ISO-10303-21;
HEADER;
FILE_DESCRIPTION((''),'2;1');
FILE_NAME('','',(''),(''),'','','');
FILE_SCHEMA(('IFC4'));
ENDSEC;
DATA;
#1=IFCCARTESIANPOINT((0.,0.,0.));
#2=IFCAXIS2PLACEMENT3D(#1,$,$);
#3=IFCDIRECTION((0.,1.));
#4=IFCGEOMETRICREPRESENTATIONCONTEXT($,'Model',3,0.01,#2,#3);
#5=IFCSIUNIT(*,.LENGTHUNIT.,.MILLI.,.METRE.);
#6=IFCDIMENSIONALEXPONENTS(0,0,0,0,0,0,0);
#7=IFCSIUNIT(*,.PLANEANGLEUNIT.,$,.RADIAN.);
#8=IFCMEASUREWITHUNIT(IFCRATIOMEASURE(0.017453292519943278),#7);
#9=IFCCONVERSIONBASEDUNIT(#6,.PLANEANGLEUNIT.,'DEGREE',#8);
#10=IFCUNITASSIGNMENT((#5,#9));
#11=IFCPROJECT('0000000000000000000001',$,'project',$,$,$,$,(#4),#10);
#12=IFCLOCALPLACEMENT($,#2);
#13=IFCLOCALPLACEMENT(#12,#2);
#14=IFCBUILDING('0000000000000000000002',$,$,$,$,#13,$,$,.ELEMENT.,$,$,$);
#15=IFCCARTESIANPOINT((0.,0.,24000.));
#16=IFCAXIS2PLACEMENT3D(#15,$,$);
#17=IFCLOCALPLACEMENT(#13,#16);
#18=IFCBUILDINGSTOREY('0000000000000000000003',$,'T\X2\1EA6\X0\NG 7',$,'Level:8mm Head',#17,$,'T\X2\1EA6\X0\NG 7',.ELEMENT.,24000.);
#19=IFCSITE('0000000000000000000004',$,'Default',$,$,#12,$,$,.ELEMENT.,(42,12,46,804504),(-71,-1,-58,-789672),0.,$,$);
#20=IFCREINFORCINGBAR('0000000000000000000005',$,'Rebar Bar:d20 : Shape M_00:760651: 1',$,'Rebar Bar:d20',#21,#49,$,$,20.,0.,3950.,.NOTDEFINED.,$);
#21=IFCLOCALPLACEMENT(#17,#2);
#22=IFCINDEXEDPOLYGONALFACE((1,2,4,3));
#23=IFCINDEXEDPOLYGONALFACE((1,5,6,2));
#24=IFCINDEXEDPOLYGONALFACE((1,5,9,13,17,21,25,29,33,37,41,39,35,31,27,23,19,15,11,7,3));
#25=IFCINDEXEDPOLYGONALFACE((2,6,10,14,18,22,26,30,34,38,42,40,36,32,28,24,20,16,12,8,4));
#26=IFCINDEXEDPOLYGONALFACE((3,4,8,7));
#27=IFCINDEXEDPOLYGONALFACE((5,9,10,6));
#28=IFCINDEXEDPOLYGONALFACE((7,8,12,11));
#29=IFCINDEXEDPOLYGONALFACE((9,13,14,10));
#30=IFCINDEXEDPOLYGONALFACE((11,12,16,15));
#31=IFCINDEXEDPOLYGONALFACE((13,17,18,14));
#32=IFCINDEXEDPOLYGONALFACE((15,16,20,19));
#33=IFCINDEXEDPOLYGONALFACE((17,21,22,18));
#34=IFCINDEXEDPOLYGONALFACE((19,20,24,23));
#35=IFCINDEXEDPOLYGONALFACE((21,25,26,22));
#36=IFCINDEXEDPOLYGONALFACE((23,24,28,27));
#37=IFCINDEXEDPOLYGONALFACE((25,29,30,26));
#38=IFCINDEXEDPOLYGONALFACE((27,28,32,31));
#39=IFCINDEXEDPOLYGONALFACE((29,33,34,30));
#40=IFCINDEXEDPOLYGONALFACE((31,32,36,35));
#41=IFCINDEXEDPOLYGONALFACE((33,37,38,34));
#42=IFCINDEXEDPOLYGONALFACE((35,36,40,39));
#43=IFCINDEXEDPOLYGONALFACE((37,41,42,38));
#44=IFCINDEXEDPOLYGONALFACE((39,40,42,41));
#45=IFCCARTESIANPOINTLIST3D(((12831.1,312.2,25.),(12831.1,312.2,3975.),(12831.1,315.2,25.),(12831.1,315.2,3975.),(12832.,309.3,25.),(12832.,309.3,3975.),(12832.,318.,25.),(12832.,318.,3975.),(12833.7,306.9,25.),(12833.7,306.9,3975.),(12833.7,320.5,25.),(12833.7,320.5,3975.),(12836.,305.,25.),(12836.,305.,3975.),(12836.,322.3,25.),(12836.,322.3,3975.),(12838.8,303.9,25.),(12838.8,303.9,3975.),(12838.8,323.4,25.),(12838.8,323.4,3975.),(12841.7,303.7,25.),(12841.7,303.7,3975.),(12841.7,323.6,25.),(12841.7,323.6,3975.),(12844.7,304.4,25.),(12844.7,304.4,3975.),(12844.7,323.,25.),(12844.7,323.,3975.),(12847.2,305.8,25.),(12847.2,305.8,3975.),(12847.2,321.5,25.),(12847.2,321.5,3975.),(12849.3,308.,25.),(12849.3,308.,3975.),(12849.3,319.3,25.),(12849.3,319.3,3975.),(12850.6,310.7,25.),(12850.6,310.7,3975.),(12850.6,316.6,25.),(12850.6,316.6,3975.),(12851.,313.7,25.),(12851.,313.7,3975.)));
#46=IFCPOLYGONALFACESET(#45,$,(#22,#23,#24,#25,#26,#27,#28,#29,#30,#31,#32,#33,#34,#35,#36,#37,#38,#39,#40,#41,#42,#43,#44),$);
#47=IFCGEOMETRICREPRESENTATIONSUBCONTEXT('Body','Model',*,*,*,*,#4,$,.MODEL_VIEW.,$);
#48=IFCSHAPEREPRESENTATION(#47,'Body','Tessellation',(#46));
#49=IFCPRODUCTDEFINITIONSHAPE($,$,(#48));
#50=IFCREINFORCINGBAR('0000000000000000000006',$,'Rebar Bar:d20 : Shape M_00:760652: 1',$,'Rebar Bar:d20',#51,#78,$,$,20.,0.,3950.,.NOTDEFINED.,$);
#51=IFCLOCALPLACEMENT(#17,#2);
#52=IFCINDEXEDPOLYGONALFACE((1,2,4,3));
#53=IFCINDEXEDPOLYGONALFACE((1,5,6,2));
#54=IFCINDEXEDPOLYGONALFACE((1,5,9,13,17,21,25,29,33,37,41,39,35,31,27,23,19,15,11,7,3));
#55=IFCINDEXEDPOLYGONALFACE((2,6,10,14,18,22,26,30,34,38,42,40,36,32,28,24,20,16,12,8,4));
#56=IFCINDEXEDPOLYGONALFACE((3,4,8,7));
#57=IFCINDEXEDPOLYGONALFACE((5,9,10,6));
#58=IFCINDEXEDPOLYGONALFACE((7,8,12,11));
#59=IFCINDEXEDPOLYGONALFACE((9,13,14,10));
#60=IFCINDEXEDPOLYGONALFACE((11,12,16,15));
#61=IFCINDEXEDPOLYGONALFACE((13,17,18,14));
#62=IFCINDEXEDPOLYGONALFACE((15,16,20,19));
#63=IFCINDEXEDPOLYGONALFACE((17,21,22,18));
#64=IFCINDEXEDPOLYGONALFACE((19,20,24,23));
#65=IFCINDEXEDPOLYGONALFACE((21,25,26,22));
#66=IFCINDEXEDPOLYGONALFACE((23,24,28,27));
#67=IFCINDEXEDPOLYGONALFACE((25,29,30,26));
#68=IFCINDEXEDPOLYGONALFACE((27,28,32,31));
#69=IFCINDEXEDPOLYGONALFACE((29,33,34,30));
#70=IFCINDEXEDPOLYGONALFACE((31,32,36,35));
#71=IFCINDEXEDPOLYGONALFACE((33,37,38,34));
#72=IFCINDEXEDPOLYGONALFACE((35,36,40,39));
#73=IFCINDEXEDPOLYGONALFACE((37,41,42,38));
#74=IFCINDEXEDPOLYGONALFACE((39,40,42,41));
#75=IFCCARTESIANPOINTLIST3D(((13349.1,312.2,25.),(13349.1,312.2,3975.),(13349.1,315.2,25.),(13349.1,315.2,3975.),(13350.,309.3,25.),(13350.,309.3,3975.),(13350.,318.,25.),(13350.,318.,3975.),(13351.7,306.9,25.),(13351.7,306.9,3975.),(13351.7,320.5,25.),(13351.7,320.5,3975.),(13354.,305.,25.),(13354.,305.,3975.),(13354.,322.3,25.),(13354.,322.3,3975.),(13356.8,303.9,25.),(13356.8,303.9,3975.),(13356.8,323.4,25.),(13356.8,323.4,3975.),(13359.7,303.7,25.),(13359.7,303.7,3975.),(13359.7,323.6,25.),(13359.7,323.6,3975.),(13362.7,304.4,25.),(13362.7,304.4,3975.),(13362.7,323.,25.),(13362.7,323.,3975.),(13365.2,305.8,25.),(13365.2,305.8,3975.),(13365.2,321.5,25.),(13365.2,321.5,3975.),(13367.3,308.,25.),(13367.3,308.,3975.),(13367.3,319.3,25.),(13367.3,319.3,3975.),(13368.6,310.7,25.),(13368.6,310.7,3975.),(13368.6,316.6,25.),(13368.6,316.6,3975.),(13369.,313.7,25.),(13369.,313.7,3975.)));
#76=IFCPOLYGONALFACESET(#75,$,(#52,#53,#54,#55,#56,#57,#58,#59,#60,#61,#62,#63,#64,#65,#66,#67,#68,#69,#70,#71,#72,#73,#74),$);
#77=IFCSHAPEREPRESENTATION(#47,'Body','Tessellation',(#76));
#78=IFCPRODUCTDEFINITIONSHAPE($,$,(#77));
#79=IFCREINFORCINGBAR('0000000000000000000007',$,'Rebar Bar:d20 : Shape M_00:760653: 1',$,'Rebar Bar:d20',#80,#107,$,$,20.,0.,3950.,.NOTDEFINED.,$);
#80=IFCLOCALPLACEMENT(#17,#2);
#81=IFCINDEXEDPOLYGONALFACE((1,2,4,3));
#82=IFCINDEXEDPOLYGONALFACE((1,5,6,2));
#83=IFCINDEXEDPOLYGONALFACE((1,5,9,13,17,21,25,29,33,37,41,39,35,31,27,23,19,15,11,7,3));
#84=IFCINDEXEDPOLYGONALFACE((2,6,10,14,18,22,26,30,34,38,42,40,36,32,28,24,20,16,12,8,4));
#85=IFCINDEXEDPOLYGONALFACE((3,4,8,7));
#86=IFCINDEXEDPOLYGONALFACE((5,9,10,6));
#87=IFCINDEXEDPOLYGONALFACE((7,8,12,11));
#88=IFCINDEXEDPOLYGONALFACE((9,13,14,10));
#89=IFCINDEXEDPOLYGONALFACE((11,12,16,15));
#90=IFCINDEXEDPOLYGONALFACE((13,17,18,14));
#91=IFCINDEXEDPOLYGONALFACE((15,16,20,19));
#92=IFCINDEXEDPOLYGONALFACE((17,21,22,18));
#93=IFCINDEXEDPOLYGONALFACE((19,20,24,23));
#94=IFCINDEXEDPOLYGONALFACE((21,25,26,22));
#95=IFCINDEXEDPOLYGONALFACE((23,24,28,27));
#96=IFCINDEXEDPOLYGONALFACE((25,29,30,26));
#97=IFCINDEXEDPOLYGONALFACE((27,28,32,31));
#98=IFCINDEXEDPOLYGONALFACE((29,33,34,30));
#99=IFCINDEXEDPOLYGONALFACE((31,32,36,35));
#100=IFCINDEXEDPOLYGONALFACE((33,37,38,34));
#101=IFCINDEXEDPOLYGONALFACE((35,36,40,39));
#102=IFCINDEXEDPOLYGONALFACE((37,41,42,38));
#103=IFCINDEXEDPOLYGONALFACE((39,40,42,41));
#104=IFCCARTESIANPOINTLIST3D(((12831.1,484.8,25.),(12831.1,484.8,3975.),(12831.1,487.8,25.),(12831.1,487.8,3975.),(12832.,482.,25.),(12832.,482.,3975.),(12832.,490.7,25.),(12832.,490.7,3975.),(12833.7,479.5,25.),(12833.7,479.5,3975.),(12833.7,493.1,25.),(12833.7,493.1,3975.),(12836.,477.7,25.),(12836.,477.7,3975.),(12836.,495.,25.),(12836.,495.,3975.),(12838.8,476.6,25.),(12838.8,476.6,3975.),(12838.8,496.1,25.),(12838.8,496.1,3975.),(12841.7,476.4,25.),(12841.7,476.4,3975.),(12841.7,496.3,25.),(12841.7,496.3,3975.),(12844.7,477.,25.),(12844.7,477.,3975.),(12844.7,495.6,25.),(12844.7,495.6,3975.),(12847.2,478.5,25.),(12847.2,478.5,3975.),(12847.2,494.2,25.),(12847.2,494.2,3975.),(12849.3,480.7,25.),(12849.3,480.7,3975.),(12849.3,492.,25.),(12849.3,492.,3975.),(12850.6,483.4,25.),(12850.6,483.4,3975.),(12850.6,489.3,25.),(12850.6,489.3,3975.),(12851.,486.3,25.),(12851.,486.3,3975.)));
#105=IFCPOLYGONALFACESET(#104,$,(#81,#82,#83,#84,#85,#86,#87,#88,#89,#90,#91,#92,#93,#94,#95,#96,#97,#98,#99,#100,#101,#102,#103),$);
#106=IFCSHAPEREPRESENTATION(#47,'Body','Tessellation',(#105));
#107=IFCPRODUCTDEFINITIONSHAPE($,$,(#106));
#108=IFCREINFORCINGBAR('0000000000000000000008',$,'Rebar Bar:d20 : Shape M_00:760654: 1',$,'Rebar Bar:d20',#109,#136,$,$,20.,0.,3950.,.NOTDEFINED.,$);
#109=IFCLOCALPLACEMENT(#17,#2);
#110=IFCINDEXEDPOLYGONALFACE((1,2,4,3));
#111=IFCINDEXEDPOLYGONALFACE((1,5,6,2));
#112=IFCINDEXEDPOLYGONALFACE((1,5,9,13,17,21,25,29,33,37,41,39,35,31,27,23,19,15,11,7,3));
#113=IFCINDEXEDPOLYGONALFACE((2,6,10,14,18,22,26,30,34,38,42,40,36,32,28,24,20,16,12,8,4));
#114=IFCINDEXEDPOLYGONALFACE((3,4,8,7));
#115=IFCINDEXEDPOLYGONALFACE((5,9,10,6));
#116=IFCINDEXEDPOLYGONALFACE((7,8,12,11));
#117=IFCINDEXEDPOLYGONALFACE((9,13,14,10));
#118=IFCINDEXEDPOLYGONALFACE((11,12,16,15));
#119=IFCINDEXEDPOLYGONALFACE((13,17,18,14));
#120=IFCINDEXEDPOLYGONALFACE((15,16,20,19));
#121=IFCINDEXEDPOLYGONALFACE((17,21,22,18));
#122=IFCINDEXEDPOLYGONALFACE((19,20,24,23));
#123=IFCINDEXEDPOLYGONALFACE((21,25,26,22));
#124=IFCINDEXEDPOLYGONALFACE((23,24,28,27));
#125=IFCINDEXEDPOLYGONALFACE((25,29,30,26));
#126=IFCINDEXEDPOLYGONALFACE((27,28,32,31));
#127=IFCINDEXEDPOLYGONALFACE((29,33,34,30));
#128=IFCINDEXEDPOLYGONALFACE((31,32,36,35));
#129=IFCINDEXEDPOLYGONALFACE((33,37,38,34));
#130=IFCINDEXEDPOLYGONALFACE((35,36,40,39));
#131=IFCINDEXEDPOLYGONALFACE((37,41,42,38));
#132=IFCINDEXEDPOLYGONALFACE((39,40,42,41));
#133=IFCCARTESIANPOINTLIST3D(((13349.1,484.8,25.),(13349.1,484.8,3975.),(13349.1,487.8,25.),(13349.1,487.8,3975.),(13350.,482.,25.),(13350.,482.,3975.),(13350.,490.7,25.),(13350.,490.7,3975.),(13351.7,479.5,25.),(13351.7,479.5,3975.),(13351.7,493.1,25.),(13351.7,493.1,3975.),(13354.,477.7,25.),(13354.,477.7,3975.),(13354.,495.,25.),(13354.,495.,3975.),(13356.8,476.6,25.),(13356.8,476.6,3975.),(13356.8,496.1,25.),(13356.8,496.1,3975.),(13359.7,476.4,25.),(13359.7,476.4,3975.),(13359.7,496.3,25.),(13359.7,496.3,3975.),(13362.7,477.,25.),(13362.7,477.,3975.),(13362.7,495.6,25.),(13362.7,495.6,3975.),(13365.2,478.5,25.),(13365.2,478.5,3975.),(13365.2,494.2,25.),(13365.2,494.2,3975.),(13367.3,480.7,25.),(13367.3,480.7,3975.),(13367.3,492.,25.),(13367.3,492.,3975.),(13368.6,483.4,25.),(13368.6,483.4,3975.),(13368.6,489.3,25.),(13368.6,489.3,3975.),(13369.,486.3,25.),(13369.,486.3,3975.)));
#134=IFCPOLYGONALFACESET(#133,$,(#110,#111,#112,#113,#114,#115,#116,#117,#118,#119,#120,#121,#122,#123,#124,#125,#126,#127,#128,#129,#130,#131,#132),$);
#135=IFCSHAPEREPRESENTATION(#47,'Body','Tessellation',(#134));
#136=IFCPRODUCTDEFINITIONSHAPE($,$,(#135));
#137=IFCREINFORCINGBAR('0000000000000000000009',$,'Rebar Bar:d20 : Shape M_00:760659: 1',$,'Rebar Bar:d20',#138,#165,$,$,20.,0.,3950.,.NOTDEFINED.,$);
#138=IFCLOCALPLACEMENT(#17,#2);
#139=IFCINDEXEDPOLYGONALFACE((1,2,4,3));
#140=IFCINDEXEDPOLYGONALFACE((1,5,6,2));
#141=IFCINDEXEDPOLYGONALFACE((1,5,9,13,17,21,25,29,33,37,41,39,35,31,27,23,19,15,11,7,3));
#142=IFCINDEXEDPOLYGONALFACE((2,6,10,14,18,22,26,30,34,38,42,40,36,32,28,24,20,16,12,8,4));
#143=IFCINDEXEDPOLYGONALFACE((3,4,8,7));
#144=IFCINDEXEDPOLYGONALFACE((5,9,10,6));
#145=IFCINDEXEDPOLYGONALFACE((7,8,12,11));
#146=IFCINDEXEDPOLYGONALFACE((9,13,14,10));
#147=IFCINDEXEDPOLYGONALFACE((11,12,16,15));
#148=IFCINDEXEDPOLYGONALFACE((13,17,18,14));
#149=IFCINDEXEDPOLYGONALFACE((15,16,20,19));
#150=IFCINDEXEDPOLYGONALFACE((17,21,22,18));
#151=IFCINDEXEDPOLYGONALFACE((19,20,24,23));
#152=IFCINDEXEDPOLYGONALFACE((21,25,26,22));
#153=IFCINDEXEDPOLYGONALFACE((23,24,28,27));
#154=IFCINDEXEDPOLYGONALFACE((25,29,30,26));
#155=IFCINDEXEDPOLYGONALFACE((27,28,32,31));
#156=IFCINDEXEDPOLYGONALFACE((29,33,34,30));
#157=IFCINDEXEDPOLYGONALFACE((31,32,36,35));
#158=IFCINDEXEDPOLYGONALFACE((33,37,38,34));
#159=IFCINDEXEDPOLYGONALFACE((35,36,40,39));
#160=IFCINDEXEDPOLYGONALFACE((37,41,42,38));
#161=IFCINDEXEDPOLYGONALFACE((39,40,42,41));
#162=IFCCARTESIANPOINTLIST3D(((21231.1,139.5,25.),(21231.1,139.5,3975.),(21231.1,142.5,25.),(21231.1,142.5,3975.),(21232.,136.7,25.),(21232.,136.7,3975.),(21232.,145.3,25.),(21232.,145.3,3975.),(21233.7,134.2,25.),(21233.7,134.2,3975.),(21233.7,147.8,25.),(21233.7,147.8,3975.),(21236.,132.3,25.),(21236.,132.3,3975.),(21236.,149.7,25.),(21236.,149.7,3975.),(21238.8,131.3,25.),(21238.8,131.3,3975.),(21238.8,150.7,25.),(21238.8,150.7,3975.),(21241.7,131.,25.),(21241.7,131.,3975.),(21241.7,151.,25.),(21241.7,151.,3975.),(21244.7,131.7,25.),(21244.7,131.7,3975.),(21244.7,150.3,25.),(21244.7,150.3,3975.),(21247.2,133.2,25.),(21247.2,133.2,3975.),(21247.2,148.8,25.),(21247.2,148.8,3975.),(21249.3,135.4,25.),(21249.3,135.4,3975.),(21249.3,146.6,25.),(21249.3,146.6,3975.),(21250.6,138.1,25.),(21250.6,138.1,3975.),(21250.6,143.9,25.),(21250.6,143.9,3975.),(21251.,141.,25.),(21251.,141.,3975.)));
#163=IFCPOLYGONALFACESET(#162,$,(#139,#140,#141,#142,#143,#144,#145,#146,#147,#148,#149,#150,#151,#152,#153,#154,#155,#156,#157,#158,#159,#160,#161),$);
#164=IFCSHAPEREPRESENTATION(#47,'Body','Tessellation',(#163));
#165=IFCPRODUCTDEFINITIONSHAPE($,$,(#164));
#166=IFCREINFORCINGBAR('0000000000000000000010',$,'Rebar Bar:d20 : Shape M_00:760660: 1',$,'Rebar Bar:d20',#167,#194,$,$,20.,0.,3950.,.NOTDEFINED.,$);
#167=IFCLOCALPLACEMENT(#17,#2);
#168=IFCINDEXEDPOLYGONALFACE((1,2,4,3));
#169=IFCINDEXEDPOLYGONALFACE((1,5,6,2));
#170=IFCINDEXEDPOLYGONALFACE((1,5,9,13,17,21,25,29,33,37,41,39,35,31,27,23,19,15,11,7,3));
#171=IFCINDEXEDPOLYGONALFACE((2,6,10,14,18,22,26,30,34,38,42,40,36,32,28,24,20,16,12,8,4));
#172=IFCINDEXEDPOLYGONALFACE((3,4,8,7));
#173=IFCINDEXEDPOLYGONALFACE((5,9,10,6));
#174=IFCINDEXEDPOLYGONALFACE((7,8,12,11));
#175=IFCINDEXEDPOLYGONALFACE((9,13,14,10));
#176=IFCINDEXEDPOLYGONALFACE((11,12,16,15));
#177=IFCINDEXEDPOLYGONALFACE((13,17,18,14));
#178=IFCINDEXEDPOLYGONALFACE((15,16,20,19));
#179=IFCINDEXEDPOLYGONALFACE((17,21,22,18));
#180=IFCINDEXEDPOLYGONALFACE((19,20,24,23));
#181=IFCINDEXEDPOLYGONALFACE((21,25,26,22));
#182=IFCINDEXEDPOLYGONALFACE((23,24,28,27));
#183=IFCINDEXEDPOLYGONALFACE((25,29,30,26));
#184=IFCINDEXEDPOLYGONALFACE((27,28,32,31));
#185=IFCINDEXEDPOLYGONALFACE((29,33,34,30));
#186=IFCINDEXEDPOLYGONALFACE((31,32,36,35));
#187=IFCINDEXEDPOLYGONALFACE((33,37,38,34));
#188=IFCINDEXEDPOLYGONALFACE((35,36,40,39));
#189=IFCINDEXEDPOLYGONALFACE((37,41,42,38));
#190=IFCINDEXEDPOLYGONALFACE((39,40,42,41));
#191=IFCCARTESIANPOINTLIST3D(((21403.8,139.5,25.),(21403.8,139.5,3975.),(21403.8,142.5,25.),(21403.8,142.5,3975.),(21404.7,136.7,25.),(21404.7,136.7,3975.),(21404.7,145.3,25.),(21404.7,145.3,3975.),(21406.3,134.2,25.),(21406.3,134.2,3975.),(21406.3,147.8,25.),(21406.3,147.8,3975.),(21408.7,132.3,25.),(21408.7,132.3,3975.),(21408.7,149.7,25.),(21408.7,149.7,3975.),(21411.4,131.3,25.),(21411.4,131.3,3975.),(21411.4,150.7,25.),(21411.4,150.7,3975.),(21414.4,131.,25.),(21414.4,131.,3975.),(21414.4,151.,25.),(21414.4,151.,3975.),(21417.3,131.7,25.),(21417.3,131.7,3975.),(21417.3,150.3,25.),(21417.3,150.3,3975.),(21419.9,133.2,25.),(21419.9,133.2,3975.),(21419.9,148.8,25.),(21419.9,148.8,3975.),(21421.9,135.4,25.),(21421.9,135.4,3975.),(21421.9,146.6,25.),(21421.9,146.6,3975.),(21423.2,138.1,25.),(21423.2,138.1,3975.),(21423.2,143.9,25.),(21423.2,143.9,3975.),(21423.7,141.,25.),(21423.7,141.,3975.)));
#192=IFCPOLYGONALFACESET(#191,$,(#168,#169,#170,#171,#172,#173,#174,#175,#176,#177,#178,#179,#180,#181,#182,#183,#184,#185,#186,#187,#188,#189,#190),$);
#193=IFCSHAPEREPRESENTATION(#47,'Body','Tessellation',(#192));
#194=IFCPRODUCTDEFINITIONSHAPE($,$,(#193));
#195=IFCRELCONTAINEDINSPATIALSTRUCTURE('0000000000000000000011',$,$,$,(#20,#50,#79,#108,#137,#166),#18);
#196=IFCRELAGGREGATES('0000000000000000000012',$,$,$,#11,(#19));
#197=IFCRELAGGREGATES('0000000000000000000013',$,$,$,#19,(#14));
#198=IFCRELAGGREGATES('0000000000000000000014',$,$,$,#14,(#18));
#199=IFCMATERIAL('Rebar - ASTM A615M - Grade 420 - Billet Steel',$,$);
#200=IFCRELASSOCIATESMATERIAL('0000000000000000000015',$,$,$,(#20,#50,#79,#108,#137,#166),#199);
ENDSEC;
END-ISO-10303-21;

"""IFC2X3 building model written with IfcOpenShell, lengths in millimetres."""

from ifc_helpers import new_model, entity, si_unit, converted_unit, direction, frame, origin, place, context, subcontext, project, spatial, material, element, save


model = new_model("IFC2X3")

# Units and contexts
model_context = context("Model", 3, precision=0.01, world=origin(), true_north=direction((0.0, 1.0)))
body_context = subcontext(model_context, "Body", "Model", "MODEL_VIEW")
ifc_project = project(units=[si_unit("LENGTHUNIT", "METRE", prefix="MILLI"), converted_unit("PLANEANGLEUNIT", "DEGREE", entity("IfcRatioMeasure", 0.017453292519943278), si_unit("PLANEANGLEUNIT", "RADIAN"), dimensions=[0, 0, 0, 0, 0, 0, 0])], contexts=[model_context])

# Site, building, storey
site_placement = place(None, origin())
site = spatial("IfcSite", under=ifc_project, at=site_placement, Name="Default", CompositionType="ELEMENT", RefLatitude=(42, 12, 46, 804504), RefLongitude=(-71, -1, -58, -789672), RefElevation=0.0)
building_placement = place(site_placement, origin())
building = spatial("IfcBuilding", under=site, at=building_placement, CompositionType="ELEMENT")
storey_placement = place(building_placement, frame((0.0, 0.0, 24000.0)))
storey = spatial("IfcBuildingStorey", under=building, at=storey_placement, Name="TẦNG 7", ObjectType="Level:8mm Head", LongName="TẦNG 7", CompositionType="ELEMENT", Elevation=24000.0)

# Reinforcing bars
ifc_material = material(Name="Rebar - ASTM A615M - Grade 420 - Billet Steel")
reinforcing_bar_1_placement = place(storey_placement, origin())
element("IfcReinforcingBar", 1, at=reinforcing_bar_1_placement, inside=storey, material=ifc_material, Name="Rebar Bar:d20 : Shape M_00:760651: 1", ObjectType="Rebar Bar:d20", BarLength=3950.0, BarRole="NOTDEFINED", CrossSectionArea=0.0, NominalDiameter=20.0, context=body_context, shape_type="AdvancedSweptSolid", body=[
    entity("IfcSweptDiskSolid", entity("IfcCompositeCurve", [entity("IfcCompositeCurveSegment", "CONTINUOUS", True, entity("IfcPolyline", [entity("IfcCartesianPoint", [12841.0, 313.7, 25.0]), entity("IfcCartesianPoint", [12841.0, 313.7, 3975.0])]))], False), 10.0, None, 0.0, 1.0),
])
reinforcing_bar_2_placement = place(storey_placement, origin())
element("IfcReinforcingBar", 2, at=reinforcing_bar_2_placement, inside=storey, material=ifc_material, Name="Rebar Bar:d20 : Shape M_00:760652: 1", ObjectType="Rebar Bar:d20", BarLength=3950.0, BarRole="NOTDEFINED", CrossSectionArea=0.0, NominalDiameter=20.0, context=body_context, shape_type="AdvancedSweptSolid", body=[
    entity("IfcSweptDiskSolid", entity("IfcCompositeCurve", [entity("IfcCompositeCurveSegment", "CONTINUOUS", True, entity("IfcPolyline", [entity("IfcCartesianPoint", [13359.0, 313.7, 25.0]), entity("IfcCartesianPoint", [13359.0, 313.7, 3975.0])]))], False), 10.0, None, 0.0, 1.0),
])
reinforcing_bar_3_placement = place(storey_placement, origin())
element("IfcReinforcingBar", 3, at=reinforcing_bar_3_placement, inside=storey, material=ifc_material, Name="Rebar Bar:d20 : Shape M_00:760653: 1", ObjectType="Rebar Bar:d20", BarLength=3950.0, BarRole="NOTDEFINED", CrossSectionArea=0.0, NominalDiameter=20.0, context=body_context, shape_type="AdvancedSweptSolid", body=[
    entity("IfcSweptDiskSolid", entity("IfcCompositeCurve", [entity("IfcCompositeCurveSegment", "CONTINUOUS", True, entity("IfcPolyline", [entity("IfcCartesianPoint", [12841.0, 486.3, 25.0]), entity("IfcCartesianPoint", [12841.0, 486.3, 3975.0])]))], False), 10.0, None, 0.0, 1.0),
])
reinforcing_bar_4_placement = place(storey_placement, origin())
element("IfcReinforcingBar", 4, at=reinforcing_bar_4_placement, inside=storey, material=ifc_material, Name="Rebar Bar:d20 : Shape M_00:760654: 1", ObjectType="Rebar Bar:d20", BarLength=3950.0, BarRole="NOTDEFINED", CrossSectionArea=0.0, NominalDiameter=20.0, context=body_context, shape_type="AdvancedSweptSolid", body=[
    entity("IfcSweptDiskSolid", entity("IfcCompositeCurve", [entity("IfcCompositeCurveSegment", "CONTINUOUS", True, entity("IfcPolyline", [entity("IfcCartesianPoint", [13359.0, 486.3, 25.0]), entity("IfcCartesianPoint", [13359.0, 486.3, 3975.0])]))], False), 10.0, None, 0.0, 1.0),
])
reinforcing_bar_5_placement = place(storey_placement, origin())
element("IfcReinforcingBar", 5, at=reinforcing_bar_5_placement, inside=storey, material=ifc_material, Name="Rebar Bar:d20 : Shape M_00:760659: 1", ObjectType="Rebar Bar:d20", BarLength=3950.0, BarRole="NOTDEFINED", CrossSectionArea=0.0, NominalDiameter=20.0, context=body_context, shape_type="AdvancedSweptSolid", body=[
    entity("IfcSweptDiskSolid", entity("IfcCompositeCurve", [entity("IfcCompositeCurveSegment", "CONTINUOUS", True, entity("IfcPolyline", [entity("IfcCartesianPoint", [21241.0, 141.0, 25.0]), entity("IfcCartesianPoint", [21241.0, 141.0, 3975.0])]))], False), 10.0, None, 0.0, 1.0),
])
reinforcing_bar_6_placement = place(storey_placement, origin())
element("IfcReinforcingBar", 6, at=reinforcing_bar_6_placement, inside=storey, material=ifc_material, Name="Rebar Bar:d20 : Shape M_00:760660: 1", ObjectType="Rebar Bar:d20", BarLength=3950.0, BarRole="NOTDEFINED", CrossSectionArea=0.0, NominalDiameter=20.0, context=body_context, shape_type="AdvancedSweptSolid", body=[
    entity("IfcSweptDiskSolid", entity("IfcCompositeCurve", [entity("IfcCompositeCurveSegment", "CONTINUOUS", True, entity("IfcPolyline", [entity("IfcCartesianPoint", [21413.7, 141.0, 25.0]), entity("IfcCartesianPoint", [21413.7, 141.0, 3975.0])]))], False), 10.0, None, 0.0, 1.0),
])

save(model, "model.ifc")
